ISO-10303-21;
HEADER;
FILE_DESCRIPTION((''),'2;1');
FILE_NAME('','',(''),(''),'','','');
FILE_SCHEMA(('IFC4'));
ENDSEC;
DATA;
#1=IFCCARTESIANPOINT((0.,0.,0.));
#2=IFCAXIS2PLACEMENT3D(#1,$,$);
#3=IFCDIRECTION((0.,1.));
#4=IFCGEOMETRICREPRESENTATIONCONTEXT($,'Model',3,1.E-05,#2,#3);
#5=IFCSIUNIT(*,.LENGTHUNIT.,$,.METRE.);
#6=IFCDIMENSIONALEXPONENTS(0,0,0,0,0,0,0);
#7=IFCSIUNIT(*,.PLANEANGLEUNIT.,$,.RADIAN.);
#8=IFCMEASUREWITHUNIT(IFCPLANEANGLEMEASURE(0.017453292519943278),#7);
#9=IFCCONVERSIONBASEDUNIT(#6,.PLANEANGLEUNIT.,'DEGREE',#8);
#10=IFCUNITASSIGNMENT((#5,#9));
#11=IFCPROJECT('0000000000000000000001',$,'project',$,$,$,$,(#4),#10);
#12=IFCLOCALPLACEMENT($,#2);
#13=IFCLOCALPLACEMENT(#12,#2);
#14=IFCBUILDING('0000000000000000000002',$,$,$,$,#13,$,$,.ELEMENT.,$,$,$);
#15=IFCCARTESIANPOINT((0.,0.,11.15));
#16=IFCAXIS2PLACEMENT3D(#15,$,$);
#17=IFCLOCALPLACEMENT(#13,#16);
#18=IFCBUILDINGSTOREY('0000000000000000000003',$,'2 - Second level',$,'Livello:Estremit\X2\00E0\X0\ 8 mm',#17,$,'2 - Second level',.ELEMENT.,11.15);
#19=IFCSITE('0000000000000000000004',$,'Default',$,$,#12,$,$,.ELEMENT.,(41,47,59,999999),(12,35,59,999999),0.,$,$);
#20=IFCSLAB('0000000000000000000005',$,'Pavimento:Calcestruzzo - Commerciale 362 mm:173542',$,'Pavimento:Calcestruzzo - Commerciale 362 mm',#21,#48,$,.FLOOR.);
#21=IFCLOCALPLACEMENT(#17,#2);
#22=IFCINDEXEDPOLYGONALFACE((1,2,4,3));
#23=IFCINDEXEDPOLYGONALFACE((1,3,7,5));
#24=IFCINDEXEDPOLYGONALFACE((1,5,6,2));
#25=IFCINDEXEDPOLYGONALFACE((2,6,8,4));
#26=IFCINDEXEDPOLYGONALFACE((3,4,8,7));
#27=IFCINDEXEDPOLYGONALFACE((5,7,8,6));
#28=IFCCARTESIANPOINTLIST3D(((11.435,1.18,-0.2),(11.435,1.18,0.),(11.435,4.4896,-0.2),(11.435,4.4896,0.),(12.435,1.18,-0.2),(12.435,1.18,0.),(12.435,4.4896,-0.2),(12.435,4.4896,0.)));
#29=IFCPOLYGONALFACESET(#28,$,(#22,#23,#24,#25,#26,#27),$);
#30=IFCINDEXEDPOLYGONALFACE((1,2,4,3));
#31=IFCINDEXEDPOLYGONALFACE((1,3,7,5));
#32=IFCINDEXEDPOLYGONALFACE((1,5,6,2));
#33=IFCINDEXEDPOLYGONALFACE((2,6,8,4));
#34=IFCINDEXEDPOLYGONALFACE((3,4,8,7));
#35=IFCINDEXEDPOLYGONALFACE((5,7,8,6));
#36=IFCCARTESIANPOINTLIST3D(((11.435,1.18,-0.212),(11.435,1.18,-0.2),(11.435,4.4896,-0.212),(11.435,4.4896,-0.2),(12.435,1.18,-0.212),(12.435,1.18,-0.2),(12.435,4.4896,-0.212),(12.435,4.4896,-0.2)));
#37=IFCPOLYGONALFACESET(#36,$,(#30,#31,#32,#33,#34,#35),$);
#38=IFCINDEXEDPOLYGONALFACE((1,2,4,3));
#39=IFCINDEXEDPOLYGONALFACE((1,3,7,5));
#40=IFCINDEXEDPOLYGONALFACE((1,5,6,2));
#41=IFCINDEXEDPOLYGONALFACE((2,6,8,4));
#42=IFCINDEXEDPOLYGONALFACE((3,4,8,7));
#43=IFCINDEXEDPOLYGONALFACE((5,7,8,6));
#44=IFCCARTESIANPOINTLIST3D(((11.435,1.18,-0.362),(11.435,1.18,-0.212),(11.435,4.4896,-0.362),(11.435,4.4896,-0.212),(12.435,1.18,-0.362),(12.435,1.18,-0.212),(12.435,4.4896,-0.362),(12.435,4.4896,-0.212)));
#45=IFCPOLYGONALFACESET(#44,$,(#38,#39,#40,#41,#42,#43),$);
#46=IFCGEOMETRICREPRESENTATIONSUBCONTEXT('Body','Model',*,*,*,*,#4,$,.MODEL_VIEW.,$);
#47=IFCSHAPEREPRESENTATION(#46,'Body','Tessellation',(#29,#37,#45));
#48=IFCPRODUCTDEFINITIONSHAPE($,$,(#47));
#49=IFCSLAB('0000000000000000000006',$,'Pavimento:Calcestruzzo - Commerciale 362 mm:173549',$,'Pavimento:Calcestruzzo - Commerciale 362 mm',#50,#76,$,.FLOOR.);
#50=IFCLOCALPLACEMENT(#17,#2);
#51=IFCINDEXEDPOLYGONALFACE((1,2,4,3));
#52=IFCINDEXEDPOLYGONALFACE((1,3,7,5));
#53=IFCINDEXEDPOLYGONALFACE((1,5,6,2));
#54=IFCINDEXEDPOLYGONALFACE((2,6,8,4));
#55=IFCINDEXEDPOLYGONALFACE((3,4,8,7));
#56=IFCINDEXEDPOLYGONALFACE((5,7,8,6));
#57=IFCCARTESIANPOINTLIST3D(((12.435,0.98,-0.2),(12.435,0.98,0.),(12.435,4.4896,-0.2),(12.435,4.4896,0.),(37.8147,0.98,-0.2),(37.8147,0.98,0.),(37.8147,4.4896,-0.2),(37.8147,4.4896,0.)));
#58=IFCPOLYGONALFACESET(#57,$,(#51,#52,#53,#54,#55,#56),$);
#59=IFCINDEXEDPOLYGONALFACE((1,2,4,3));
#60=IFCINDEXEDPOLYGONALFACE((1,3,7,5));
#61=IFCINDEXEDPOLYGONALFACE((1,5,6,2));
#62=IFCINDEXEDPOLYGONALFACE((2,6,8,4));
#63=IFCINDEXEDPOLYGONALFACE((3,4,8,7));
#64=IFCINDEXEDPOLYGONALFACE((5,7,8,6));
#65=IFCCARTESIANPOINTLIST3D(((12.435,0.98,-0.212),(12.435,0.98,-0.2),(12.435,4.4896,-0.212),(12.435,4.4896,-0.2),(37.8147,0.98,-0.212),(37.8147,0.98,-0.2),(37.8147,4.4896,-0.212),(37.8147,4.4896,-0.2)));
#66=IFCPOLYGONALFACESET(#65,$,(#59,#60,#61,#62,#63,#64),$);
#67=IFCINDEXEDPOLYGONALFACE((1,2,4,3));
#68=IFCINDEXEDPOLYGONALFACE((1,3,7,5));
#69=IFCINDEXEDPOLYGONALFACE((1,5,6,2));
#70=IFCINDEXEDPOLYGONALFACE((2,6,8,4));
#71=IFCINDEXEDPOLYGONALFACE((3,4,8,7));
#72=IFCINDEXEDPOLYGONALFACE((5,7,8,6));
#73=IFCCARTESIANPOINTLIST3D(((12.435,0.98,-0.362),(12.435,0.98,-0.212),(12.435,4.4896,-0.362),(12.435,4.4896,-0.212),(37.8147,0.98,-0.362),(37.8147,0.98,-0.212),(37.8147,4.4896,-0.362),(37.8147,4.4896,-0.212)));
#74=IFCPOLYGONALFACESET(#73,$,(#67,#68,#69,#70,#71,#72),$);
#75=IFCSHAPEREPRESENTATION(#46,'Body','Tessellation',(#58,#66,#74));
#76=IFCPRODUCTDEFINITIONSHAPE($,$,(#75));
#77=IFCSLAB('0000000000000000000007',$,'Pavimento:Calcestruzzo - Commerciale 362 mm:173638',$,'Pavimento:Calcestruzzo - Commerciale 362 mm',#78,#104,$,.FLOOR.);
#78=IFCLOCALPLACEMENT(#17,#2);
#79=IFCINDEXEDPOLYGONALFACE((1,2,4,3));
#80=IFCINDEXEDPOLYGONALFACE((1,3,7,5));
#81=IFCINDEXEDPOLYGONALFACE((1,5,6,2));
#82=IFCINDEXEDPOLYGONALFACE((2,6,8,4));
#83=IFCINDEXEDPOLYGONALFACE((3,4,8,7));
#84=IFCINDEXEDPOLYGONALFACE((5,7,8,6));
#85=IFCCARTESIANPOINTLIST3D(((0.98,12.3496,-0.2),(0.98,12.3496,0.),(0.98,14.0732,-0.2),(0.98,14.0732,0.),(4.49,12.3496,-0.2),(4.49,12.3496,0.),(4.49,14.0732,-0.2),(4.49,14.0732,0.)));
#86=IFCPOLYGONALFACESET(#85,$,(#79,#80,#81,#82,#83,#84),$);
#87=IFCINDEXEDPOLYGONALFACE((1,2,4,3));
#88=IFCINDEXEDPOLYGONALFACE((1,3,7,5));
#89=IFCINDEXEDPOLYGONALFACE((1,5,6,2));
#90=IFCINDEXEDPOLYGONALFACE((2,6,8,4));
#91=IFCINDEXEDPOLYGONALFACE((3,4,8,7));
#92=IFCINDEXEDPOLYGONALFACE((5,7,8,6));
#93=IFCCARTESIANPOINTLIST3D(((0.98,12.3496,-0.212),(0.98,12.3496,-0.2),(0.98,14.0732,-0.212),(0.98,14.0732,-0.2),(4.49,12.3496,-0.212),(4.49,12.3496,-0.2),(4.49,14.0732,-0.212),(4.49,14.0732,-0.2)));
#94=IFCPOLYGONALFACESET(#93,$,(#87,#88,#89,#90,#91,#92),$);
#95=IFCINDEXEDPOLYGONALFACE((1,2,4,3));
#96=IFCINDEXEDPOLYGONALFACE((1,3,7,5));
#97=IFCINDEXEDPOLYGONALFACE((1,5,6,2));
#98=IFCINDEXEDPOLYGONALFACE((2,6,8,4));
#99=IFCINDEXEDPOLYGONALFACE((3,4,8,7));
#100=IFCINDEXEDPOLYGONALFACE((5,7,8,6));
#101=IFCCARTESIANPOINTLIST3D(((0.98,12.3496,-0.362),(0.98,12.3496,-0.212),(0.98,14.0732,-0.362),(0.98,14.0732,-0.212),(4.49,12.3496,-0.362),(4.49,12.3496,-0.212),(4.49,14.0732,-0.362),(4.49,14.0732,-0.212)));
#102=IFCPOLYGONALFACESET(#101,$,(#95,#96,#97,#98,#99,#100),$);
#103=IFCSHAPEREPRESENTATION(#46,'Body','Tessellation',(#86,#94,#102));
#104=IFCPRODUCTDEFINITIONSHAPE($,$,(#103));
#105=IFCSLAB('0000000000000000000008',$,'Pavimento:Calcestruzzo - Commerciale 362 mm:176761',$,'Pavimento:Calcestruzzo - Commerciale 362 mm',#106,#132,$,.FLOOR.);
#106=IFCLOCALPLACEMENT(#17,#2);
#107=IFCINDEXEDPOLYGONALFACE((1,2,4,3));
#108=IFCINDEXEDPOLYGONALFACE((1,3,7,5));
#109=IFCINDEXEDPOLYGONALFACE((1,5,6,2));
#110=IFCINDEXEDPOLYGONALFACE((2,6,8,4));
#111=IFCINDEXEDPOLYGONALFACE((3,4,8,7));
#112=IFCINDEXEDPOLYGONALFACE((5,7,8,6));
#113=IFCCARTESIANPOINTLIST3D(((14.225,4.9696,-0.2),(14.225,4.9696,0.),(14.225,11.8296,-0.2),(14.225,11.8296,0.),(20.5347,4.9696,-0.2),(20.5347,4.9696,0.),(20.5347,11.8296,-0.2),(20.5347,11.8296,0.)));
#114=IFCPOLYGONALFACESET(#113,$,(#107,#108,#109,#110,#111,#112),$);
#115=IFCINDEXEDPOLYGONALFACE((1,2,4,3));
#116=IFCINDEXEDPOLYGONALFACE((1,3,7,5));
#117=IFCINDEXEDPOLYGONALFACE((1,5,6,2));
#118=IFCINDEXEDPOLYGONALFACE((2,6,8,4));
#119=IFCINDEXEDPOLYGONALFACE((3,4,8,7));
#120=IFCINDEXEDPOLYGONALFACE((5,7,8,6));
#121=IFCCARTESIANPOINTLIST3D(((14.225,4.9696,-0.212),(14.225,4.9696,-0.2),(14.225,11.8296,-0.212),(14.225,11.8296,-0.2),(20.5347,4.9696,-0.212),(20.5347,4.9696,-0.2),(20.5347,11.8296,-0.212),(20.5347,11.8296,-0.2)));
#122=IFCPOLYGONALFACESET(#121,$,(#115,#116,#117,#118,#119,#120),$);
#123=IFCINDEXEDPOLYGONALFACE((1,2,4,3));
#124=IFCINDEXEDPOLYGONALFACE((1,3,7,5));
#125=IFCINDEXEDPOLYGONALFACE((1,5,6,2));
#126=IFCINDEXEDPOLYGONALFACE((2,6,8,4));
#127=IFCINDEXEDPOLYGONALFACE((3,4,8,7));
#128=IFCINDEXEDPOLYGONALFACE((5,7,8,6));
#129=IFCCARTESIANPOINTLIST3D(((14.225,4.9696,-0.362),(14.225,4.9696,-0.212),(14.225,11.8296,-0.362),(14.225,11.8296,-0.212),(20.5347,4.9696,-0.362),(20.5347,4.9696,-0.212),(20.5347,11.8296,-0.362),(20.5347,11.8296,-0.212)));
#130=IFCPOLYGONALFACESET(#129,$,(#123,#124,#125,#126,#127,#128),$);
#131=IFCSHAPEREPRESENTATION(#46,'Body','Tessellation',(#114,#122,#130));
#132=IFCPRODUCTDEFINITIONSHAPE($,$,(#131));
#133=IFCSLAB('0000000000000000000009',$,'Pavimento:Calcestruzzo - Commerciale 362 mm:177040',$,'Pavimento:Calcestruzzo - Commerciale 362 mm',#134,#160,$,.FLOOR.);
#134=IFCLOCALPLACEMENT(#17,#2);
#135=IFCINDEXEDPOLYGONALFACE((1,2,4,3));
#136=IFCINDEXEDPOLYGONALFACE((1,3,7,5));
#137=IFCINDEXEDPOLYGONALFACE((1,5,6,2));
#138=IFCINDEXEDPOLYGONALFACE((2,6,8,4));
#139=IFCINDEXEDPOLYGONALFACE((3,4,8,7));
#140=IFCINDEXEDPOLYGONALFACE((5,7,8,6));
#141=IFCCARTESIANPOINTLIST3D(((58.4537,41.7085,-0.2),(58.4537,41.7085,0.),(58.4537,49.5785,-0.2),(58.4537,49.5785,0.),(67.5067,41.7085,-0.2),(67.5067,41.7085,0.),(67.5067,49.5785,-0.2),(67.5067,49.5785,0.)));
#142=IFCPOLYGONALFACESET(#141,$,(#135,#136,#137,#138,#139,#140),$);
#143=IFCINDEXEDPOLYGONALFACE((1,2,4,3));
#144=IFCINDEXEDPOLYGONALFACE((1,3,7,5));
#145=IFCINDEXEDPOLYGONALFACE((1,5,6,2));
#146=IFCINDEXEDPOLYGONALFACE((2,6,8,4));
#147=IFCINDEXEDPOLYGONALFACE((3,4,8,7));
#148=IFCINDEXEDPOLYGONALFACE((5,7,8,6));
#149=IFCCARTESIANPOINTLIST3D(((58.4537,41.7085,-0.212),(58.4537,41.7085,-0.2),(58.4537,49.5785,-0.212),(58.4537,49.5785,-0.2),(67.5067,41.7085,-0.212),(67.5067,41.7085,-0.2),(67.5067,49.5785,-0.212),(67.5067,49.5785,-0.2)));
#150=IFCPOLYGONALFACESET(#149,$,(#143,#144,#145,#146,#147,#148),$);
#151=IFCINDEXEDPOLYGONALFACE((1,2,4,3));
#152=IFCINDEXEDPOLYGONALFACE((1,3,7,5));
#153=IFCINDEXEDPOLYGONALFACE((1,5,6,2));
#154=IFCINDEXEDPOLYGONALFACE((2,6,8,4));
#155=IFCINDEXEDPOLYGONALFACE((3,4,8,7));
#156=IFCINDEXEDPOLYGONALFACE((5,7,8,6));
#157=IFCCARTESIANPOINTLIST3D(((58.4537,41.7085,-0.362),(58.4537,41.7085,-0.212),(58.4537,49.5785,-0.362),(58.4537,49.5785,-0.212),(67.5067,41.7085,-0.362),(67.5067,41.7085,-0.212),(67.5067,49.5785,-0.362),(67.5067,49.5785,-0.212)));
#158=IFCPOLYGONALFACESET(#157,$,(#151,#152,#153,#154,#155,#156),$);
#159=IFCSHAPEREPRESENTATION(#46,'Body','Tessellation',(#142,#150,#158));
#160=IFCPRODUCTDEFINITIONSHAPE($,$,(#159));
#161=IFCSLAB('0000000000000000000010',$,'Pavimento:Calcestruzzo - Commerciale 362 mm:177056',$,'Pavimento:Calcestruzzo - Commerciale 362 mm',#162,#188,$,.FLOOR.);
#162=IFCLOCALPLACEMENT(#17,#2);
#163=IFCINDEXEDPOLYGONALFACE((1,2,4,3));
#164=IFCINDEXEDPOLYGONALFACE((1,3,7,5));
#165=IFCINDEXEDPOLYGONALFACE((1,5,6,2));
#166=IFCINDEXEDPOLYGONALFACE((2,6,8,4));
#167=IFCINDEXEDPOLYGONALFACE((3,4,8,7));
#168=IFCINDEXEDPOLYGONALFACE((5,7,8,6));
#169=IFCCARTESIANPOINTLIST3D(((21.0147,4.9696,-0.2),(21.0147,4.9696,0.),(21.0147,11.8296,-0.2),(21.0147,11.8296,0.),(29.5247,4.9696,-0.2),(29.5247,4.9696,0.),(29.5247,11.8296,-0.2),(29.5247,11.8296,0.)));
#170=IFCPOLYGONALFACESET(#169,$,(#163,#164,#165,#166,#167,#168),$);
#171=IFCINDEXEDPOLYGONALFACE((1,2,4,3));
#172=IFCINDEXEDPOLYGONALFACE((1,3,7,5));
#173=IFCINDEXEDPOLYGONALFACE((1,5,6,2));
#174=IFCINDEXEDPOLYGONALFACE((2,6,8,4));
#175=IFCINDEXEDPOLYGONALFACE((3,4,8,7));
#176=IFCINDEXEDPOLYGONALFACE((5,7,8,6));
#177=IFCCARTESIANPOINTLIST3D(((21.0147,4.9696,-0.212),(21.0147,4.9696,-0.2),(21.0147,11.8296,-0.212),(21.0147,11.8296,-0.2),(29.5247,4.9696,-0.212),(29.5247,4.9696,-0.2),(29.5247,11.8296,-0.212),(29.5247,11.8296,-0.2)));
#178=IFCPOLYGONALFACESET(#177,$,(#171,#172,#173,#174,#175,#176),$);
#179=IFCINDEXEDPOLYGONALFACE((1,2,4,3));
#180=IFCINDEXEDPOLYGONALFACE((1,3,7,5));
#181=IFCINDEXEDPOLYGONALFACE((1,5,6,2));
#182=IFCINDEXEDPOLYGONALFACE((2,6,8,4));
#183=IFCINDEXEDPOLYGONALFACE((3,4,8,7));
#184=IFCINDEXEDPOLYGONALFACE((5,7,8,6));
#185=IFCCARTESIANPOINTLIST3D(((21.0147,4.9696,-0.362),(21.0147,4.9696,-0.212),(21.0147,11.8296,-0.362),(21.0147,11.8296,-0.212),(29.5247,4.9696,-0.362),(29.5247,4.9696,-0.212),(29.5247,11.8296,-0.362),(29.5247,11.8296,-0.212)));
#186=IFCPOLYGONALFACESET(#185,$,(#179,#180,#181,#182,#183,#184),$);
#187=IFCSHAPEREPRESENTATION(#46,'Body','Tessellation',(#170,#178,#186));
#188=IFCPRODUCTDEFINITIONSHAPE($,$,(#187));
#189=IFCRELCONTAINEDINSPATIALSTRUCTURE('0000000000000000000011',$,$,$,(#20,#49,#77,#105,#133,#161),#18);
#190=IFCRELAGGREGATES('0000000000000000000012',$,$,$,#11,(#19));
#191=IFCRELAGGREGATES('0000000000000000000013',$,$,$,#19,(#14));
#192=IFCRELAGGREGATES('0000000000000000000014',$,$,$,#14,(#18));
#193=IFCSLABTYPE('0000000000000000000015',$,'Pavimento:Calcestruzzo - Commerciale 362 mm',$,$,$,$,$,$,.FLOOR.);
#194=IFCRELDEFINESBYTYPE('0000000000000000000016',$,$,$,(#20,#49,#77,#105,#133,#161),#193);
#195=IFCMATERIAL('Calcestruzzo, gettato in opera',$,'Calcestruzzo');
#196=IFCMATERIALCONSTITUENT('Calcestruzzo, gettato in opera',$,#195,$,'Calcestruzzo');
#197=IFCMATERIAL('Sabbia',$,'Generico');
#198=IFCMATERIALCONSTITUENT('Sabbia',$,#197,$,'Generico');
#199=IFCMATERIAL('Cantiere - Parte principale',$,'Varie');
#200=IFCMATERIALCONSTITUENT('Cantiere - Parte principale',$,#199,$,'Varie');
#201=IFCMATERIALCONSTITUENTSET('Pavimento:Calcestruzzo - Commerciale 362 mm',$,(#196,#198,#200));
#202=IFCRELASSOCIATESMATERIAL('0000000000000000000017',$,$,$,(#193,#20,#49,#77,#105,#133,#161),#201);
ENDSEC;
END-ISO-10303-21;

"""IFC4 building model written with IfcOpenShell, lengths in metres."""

from ifc_helpers import new_model, entity, si_unit, converted_unit, direction, frame, origin, place, context, subcontext, project, spatial, indexed_curve, outline, extrude, material, constituent, constituent_set, type_object, element, save


model = new_model("IFC4")

# Units and contexts
model_context = context("Model", 3, precision=1e-05, world=origin(), true_north=direction((0.0, 1.0)))
body_context = subcontext(model_context, "Body", "Model", "MODEL_VIEW")
ifc_project = project(units=[si_unit("LENGTHUNIT", "METRE"), converted_unit("PLANEANGLEUNIT", "DEGREE", entity("IfcPlaneAngleMeasure", 0.017453292519943278), si_unit("PLANEANGLEUNIT", "RADIAN"), dimensions=[0, 0, 0, 0, 0, 0, 0])], contexts=[model_context])

# Site, building, storey
site_placement = place(None, origin())
site = spatial("IfcSite", under=ifc_project, at=site_placement, Name="Default", CompositionType="ELEMENT", RefLatitude=(41, 47, 59, 999999), RefLongitude=(12, 35, 59, 999999), RefElevation=0.0)
building_placement = place(site_placement, origin())
building = spatial("IfcBuilding", under=site, at=building_placement, CompositionType="ELEMENT")
storey_placement = place(building_placement, frame((0.0, 0.0, 11.15)))
storey = spatial("IfcBuildingStorey", under=building, at=storey_placement, Name="2 - Second level", ObjectType="Livello:Estremità 8 mm", LongName="2 - Second level", CompositionType="ELEMENT", Elevation=11.15)

# Slabs
ifc_material_1 = material(Name="Calcestruzzo, gettato in opera", Category="Calcestruzzo")
ifc_constituent_1 = constituent(ifc_material_1, Name="Calcestruzzo, gettato in opera", Category="Calcestruzzo")
ifc_material_2 = material(Name="Sabbia", Category="Generico")
ifc_constituent_2 = constituent(ifc_material_2, Name="Sabbia", Category="Generico")
ifc_material_3 = material(Name="Cantiere - Parte principale", Category="Varie")
ifc_constituent_3 = constituent(ifc_material_3, Name="Cantiere - Parte principale", Category="Varie")
ifc_constituent_set = constituent_set(constituents=[ifc_constituent_1, ifc_constituent_2, ifc_constituent_3], Name="Pavimento:Calcestruzzo - Commerciale 362 mm")
slab_type = type_object("IfcSlabType", Name="Pavimento:Calcestruzzo - Commerciale 362 mm", PredefinedType="FLOOR", material=ifc_constituent_set)
slab_1_placement = place(storey_placement, origin())
element("IfcSlab", 1, at=slab_1_placement, inside=storey, type_object=slab_type, material=ifc_constituent_set, Name="Pavimento:Calcestruzzo - Commerciale 362 mm:173542", ObjectType="Pavimento:Calcestruzzo - Commerciale 362 mm", PredefinedType="FLOOR", context=body_context, shape_type="SweptSolid", body=[
    extrude(outline(indexed_curve([(-1.6548, -0.5), (1.6548, -0.5), (1.6548, 0.5), (-1.6548, 0.5), (-1.6548, -0.5)], self_intersect=False)), frame((11.935, 2.8348, -0.2), z_axis=(0.0, 0.0, 1.0), x_axis=(0.0, 1.0, 0.0)), (0.0, 0.0, 1.0), 0.2),
    extrude(outline(indexed_curve([(-1.6548, -0.5), (1.6548, -0.5), (1.6548, 0.5), (-1.6548, 0.5), (-1.6548, -0.5)], self_intersect=False)), frame((11.935, 2.8348, -0.212), z_axis=(0.0, 0.0, 1.0), x_axis=(0.0, 1.0, 0.0)), (0.0, 0.0, 1.0), 0.012),
    extrude(outline(indexed_curve([(-1.6548, -0.5), (1.6548, -0.5), (1.6548, 0.5), (-1.6548, 0.5), (-1.6548, -0.5)], self_intersect=False)), frame((11.935, 2.8348, -0.362), z_axis=(0.0, 0.0, 1.0), x_axis=(0.0, 1.0, 0.0)), (0.0, 0.0, 1.0), 0.15),
])
slab_2_placement = place(storey_placement, origin())
element("IfcSlab", 2, at=slab_2_placement, inside=storey, type_object=slab_type, material=ifc_constituent_set, Name="Pavimento:Calcestruzzo - Commerciale 362 mm:173549", ObjectType="Pavimento:Calcestruzzo - Commerciale 362 mm", PredefinedType="FLOOR", context=body_context, shape_type="SweptSolid", body=[
    extrude(outline(indexed_curve([(-1.7548, -12.6898), (1.7548, -12.6898), (1.7548, 12.6898), (-1.7548, 12.6898), (-1.7548, -12.6898)], self_intersect=False)), frame((25.1249, 2.7348, -0.2), z_axis=(0.0, 0.0, 1.0), x_axis=(0.0, 1.0, 0.0)), (0.0, 0.0, 1.0), 0.2),
    extrude(outline(indexed_curve([(-1.7548, -12.6898), (1.7548, -12.6898), (1.7548, 12.6898), (-1.7548, 12.6898), (-1.7548, -12.6898)], self_intersect=False)), frame((25.1249, 2.7348, -0.212), z_axis=(0.0, 0.0, 1.0), x_axis=(0.0, 1.0, 0.0)), (0.0, 0.0, 1.0), 0.012),
    extrude(outline(indexed_curve([(-1.7548, -12.6898), (1.7548, -12.6898), (1.7548, 12.6898), (-1.7548, 12.6898), (-1.7548, -12.6898)], self_intersect=False)), frame((25.1249, 2.7348, -0.362), z_axis=(0.0, 0.0, 1.0), x_axis=(0.0, 1.0, 0.0)), (0.0, 0.0, 1.0), 0.15),
])
slab_3_placement = place(storey_placement, origin())
element("IfcSlab", 3, at=slab_3_placement, inside=storey, type_object=slab_type, material=ifc_constituent_set, Name="Pavimento:Calcestruzzo - Commerciale 362 mm:173638", ObjectType="Pavimento:Calcestruzzo - Commerciale 362 mm", PredefinedType="FLOOR", context=body_context, shape_type="SweptSolid", body=[
    extrude(outline(indexed_curve([(-0.8618, -1.755), (0.8618, -1.755), (0.8618, 1.755), (-0.8618, 1.755), (-0.8618, -1.755)], self_intersect=False)), frame((2.735, 13.2114, -0.2), z_axis=(0.0, 0.0, 1.0), x_axis=(0.0, -1.0, 0.0)), (0.0, 0.0, 1.0), 0.2),
    extrude(outline(indexed_curve([(-0.8618, -1.755), (0.8618, -1.755), (0.8618, 1.755), (-0.8618, 1.755), (-0.8618, -1.755)], self_intersect=False)), frame((2.735, 13.2114, -0.212), z_axis=(0.0, 0.0, 1.0), x_axis=(0.0, -1.0, 0.0)), (0.0, 0.0, 1.0), 0.012),
    extrude(outline(indexed_curve([(-0.8618, -1.755), (0.8618, -1.755), (0.8618, 1.755), (-0.8618, 1.755), (-0.8618, -1.755)], self_intersect=False)), frame((2.735, 13.2114, -0.362), z_axis=(0.0, 0.0, 1.0), x_axis=(0.0, -1.0, 0.0)), (0.0, 0.0, 1.0), 0.15),
])
slab_4_placement = place(storey_placement, origin())
element("IfcSlab", 4, at=slab_4_placement, inside=storey, type_object=slab_type, material=ifc_constituent_set, Name="Pavimento:Calcestruzzo - Commerciale 362 mm:176761", ObjectType="Pavimento:Calcestruzzo - Commerciale 362 mm", PredefinedType="FLOOR", context=body_context, shape_type="SweptSolid", body=[
    extrude(outline(indexed_curve([(-3.1548, -3.43), (3.1548, -3.43), (3.1548, 3.43), (-3.1548, 3.43), (-3.1548, -3.43)], self_intersect=False)), frame((17.3799, 8.3996, -0.2), z_axis=(0.0, 0.0, 1.0), x_axis=(-1.0, 0.0, 0.0)), (0.0, 0.0, 1.0), 0.2),
    extrude(outline(indexed_curve([(-3.1548, -3.43), (3.1548, -3.43), (3.1548, 3.43), (-3.1548, 3.43), (-3.1548, -3.43)], self_intersect=False)), frame((17.3799, 8.3996, -0.212), z_axis=(0.0, 0.0, 1.0), x_axis=(-1.0, 0.0, 0.0)), (0.0, 0.0, 1.0), 0.012),
    extrude(outline(indexed_curve([(-3.1548, -3.43), (3.1548, -3.43), (3.1548, 3.43), (-3.1548, 3.43), (-3.1548, -3.43)], self_intersect=False)), frame((17.3799, 8.3996, -0.362), z_axis=(0.0, 0.0, 1.0), x_axis=(-1.0, 0.0, 0.0)), (0.0, 0.0, 1.0), 0.15),
])
slab_5_placement = place(storey_placement, origin())
element("IfcSlab", 5, at=slab_5_placement, inside=storey, type_object=slab_type, material=ifc_constituent_set, Name="Pavimento:Calcestruzzo - Commerciale 362 mm:177040", ObjectType="Pavimento:Calcestruzzo - Commerciale 362 mm", PredefinedType="FLOOR", context=body_context, shape_type="SweptSolid", body=[
    extrude(outline(indexed_curve([(-4.5265, -3.935), (4.5265, -3.935), (4.5265, 3.935), (-4.5265, 3.935), (-4.5265, -3.935)], self_intersect=False)), frame((62.9802, 45.6435, -0.2)), (0.0, 0.0, 1.0), 0.2),
    extrude(outline(indexed_curve([(-4.5265, -3.935), (4.5265, -3.935), (4.5265, 3.935), (-4.5265, 3.935), (-4.5265, -3.935)], self_intersect=False)), frame((62.9802, 45.6435, -0.212)), (0.0, 0.0, 1.0), 0.012),
    extrude(outline(indexed_curve([(-4.5265, -3.935), (4.5265, -3.935), (4.5265, 3.935), (-4.5265, 3.935), (-4.5265, -3.935)], self_intersect=False)), frame((62.9802, 45.6435, -0.362)), (0.0, 0.0, 1.0), 0.15),
])
slab_6_placement = place(storey_placement, origin())
element("IfcSlab", 6, at=slab_6_placement, inside=storey, type_object=slab_type, material=ifc_constituent_set, Name="Pavimento:Calcestruzzo - Commerciale 362 mm:177056", ObjectType="Pavimento:Calcestruzzo - Commerciale 362 mm", PredefinedType="FLOOR", context=body_context, shape_type="SweptSolid", body=[
    extrude(outline(indexed_curve([(-3.43, -4.255), (3.43, -4.255), (3.43, 4.255), (-3.43, 4.255), (-3.43, -4.255)], self_intersect=False)), frame((25.2697, 8.3996, -0.2), z_axis=(0.0, 0.0, 1.0), x_axis=(0.0, 1.0, 0.0)), (0.0, 0.0, 1.0), 0.2),
    extrude(outline(indexed_curve([(-3.43, -4.255), (3.43, -4.255), (3.43, 4.255), (-3.43, 4.255), (-3.43, -4.255)], self_intersect=False)), frame((25.2697, 8.3996, -0.212), z_axis=(0.0, 0.0, 1.0), x_axis=(0.0, 1.0, 0.0)), (0.0, 0.0, 1.0), 0.012),
    extrude(outline(indexed_curve([(-3.43, -4.255), (3.43, -4.255), (3.43, 4.255), (-3.43, 4.255), (-3.43, -4.255)], self_intersect=False)), frame((25.2697, 8.3996, -0.362), z_axis=(0.0, 0.0, 1.0), x_axis=(0.0, 1.0, 0.0)), (0.0, 0.0, 1.0), 0.15),
])

save(model, "model.ifc")
